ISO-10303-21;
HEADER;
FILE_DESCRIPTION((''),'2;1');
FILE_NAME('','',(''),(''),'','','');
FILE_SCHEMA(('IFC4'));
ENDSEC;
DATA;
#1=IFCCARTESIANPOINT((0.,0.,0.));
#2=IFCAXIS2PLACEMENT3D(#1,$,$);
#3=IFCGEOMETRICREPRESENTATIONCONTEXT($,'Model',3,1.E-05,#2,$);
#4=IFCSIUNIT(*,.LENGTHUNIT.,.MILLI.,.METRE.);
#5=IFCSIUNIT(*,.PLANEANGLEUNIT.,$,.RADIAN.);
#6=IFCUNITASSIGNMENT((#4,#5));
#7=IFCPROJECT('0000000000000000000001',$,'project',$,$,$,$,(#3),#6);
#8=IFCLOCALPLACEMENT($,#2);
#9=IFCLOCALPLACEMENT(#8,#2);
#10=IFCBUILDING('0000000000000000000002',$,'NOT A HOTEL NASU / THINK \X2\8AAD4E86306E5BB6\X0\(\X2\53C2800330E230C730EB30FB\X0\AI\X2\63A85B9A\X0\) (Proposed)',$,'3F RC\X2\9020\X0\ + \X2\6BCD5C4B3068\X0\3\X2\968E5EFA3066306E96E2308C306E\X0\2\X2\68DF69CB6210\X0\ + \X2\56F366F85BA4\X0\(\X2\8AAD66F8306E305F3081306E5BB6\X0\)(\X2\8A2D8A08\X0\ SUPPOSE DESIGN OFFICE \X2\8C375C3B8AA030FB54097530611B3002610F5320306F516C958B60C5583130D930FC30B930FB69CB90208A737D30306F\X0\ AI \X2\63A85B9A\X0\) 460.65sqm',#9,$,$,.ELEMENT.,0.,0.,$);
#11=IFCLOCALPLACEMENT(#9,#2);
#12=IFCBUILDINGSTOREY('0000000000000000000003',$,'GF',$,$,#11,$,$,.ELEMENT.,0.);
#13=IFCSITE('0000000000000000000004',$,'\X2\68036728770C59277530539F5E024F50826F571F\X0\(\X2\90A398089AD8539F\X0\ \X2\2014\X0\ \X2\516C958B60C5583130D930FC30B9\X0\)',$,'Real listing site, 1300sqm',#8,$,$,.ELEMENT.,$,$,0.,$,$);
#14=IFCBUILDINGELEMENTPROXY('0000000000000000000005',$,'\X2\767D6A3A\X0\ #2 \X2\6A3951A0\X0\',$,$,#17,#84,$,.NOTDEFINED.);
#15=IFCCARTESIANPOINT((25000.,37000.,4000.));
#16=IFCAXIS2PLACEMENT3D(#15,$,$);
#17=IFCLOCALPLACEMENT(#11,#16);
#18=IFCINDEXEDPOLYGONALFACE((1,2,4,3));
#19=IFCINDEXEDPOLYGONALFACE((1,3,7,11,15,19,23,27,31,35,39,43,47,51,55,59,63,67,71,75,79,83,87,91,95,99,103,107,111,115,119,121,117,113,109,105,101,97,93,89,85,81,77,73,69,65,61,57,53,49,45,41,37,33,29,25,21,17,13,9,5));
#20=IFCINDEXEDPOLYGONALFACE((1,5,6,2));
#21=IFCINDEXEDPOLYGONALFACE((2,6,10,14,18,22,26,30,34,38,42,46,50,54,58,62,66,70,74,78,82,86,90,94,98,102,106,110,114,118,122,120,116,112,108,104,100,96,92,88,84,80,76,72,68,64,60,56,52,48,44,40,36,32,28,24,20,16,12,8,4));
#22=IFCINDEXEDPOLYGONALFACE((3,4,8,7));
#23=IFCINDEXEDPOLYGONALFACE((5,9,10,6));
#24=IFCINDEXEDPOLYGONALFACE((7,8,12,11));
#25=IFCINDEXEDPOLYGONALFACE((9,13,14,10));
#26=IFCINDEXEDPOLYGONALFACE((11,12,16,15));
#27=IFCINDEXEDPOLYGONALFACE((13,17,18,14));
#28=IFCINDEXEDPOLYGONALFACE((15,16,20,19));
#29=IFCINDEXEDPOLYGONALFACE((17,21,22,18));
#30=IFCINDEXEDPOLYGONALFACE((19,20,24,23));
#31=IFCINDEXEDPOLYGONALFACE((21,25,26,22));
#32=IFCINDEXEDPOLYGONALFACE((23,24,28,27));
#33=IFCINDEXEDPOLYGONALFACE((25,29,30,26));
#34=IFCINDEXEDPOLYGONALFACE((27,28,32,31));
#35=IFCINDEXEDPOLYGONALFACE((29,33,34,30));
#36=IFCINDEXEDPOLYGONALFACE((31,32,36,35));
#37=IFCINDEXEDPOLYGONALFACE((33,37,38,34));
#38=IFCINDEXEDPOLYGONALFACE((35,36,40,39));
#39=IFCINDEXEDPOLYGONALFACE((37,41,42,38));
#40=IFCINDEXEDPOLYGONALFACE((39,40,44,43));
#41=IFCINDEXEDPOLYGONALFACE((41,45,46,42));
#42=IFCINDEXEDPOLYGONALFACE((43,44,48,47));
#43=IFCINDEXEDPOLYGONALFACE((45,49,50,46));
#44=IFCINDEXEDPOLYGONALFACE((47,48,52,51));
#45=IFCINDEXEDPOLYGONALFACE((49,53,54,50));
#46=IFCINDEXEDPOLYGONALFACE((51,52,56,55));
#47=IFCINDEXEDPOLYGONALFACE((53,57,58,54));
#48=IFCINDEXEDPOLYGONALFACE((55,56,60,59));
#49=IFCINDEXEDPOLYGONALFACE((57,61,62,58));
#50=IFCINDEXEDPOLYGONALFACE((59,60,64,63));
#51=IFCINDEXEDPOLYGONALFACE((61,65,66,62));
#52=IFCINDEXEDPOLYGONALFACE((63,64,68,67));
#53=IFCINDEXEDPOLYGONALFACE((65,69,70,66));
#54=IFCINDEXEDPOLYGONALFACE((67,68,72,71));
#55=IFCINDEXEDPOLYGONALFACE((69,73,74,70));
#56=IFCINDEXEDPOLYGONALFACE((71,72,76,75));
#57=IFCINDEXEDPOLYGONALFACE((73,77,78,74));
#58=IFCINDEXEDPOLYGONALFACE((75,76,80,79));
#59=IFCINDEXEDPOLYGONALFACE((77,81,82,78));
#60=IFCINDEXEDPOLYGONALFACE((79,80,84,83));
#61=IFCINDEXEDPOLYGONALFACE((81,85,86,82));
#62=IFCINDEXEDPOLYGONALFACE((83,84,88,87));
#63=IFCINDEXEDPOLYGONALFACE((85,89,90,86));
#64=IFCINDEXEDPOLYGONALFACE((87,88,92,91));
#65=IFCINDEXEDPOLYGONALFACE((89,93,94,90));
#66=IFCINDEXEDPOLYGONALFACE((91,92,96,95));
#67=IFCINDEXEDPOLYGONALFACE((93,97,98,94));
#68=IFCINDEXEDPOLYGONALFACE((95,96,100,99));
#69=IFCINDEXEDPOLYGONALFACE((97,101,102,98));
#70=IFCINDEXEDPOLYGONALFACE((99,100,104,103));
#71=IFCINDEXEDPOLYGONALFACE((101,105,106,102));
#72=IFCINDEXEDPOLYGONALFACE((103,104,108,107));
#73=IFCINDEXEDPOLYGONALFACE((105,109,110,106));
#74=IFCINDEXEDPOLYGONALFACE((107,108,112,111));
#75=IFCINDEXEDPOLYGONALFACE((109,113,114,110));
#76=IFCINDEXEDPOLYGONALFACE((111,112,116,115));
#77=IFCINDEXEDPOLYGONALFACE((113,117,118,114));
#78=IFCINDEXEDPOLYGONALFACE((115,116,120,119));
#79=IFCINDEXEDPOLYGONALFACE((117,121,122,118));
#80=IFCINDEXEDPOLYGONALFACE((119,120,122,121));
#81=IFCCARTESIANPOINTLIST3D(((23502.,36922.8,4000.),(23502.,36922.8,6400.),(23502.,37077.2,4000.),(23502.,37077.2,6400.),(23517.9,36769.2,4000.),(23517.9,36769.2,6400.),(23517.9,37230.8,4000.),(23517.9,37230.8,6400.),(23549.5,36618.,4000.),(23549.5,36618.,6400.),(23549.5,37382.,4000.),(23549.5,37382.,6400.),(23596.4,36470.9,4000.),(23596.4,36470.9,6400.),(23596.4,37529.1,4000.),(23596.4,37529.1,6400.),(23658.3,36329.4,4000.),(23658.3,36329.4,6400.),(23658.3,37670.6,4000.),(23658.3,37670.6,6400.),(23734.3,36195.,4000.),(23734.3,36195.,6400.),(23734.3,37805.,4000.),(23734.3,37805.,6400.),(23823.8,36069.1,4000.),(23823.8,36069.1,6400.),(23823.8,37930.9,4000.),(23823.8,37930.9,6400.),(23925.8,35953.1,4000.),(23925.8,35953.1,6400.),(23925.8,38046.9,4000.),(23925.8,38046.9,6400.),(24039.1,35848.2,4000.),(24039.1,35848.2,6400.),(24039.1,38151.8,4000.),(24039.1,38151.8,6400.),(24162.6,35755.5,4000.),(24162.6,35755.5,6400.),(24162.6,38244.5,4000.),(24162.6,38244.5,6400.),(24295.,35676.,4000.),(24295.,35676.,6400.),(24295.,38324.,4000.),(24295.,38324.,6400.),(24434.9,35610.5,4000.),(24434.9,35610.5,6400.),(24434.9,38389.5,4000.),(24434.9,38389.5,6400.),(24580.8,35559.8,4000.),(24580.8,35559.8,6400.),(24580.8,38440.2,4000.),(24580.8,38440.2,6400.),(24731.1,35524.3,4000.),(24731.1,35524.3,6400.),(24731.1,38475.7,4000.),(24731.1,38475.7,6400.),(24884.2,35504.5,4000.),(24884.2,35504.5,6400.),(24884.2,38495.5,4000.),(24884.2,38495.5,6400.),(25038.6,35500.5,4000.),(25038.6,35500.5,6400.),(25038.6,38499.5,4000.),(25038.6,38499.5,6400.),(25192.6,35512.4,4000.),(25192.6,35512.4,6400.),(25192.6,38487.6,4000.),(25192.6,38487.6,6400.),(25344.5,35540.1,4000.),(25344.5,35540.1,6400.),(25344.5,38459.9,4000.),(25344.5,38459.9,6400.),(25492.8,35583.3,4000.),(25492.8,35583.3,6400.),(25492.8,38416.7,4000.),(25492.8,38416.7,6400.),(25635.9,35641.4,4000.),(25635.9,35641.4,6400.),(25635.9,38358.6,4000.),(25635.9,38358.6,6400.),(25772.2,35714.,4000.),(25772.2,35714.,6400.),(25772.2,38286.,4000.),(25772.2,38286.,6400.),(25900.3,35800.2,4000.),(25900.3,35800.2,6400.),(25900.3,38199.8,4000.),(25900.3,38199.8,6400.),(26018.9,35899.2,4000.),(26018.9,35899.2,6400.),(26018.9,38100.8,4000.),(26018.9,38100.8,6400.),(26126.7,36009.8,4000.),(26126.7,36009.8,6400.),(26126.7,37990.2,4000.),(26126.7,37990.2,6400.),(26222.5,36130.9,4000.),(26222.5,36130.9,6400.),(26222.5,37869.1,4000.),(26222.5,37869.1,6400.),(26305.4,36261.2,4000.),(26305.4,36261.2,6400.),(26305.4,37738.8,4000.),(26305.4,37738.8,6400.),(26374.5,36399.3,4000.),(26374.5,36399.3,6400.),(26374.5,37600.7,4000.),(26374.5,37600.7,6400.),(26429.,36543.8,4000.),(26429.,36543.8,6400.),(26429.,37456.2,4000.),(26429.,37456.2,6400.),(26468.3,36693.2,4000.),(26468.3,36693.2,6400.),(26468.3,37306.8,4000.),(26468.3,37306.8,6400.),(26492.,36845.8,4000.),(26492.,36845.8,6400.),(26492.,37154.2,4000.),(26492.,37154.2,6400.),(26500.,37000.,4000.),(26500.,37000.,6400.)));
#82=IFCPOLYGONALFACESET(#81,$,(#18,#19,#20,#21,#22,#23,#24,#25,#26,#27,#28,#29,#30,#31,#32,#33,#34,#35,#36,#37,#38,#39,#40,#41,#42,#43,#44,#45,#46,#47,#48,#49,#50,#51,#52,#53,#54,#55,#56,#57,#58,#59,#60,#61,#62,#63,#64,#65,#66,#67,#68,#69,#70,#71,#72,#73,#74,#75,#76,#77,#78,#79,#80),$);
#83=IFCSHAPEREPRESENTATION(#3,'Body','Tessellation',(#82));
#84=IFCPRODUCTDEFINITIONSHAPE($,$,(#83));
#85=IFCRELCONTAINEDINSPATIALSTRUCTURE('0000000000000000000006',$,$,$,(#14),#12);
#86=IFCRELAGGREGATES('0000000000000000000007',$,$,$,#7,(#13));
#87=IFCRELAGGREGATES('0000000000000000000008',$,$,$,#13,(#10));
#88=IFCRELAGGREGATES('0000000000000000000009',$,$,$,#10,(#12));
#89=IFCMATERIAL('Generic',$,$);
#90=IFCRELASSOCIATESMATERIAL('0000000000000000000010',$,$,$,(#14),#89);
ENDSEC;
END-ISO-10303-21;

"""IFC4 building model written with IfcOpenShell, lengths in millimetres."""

from ifc_helpers import new_model, si_unit, frame, origin, origin_2d, place, context, project, spatial, circle, extrude, material, element, save


model = new_model("IFC4")

# Units and contexts
model_context = context("Model", 3, precision=1e-05, world=origin())
ifc_project = project(units=[si_unit("LENGTHUNIT", "METRE", prefix="MILLI"), si_unit("PLANEANGLEUNIT", "RADIAN")], contexts=[model_context])

# Site, building, storey
site_placement = place(None, origin())
site = spatial("IfcSite", under=ifc_project, at=site_placement, Name="栃木県大田原市佐良土(那須高原 — 公開情報ベース)", ObjectType="Real listing site, 1300sqm", CompositionType="ELEMENT", RefElevation=0.0)
building_placement = place(site_placement, origin())
building = spatial("IfcBuilding", under=site, at=building_placement, Name="NOT A HOTEL NASU / THINK 読了の家(参考モデル・AI推定) (Proposed)", ObjectType="3F RC造 + 母屋と3階建ての離れの2棟構成 + 図書室(読書のための家)(設計 SUPPOSE DESIGN OFFICE 谷尻誠・吉田愛。意匠は公開情報ベース・構造詳細は AI 推定) 460.65sqm", CompositionType="ELEMENT", ElevationOfRefHeight=0.0, ElevationOfTerrain=0.0)
storey_placement = place(building_placement, origin())
storey = spatial("IfcBuildingStorey", under=building, at=storey_placement, Name="GF", CompositionType="ELEMENT", Elevation=0.0)

# Shared definitions
ifc_material_1 = material(Name="Generic")

# Building element proxy
proxy_1_placement = place(storey_placement, frame((25000.0, 37000.0, 4000.0)))
element("IfcBuildingElementProxy", 1, at=proxy_1_placement, inside=storey, material=ifc_material_1, Name="白樺 #2 樹冠", PredefinedType="NOTDEFINED", context=model_context, shape_type="SweptSolid", body=[
    extrude(circle(Radius=1500.0, at=origin_2d()), frame((25000.0, 37000.0, 4000.0)), (0.0, 0.0, 1.0), 2400.0),
])

save(model, "model.ifc")
